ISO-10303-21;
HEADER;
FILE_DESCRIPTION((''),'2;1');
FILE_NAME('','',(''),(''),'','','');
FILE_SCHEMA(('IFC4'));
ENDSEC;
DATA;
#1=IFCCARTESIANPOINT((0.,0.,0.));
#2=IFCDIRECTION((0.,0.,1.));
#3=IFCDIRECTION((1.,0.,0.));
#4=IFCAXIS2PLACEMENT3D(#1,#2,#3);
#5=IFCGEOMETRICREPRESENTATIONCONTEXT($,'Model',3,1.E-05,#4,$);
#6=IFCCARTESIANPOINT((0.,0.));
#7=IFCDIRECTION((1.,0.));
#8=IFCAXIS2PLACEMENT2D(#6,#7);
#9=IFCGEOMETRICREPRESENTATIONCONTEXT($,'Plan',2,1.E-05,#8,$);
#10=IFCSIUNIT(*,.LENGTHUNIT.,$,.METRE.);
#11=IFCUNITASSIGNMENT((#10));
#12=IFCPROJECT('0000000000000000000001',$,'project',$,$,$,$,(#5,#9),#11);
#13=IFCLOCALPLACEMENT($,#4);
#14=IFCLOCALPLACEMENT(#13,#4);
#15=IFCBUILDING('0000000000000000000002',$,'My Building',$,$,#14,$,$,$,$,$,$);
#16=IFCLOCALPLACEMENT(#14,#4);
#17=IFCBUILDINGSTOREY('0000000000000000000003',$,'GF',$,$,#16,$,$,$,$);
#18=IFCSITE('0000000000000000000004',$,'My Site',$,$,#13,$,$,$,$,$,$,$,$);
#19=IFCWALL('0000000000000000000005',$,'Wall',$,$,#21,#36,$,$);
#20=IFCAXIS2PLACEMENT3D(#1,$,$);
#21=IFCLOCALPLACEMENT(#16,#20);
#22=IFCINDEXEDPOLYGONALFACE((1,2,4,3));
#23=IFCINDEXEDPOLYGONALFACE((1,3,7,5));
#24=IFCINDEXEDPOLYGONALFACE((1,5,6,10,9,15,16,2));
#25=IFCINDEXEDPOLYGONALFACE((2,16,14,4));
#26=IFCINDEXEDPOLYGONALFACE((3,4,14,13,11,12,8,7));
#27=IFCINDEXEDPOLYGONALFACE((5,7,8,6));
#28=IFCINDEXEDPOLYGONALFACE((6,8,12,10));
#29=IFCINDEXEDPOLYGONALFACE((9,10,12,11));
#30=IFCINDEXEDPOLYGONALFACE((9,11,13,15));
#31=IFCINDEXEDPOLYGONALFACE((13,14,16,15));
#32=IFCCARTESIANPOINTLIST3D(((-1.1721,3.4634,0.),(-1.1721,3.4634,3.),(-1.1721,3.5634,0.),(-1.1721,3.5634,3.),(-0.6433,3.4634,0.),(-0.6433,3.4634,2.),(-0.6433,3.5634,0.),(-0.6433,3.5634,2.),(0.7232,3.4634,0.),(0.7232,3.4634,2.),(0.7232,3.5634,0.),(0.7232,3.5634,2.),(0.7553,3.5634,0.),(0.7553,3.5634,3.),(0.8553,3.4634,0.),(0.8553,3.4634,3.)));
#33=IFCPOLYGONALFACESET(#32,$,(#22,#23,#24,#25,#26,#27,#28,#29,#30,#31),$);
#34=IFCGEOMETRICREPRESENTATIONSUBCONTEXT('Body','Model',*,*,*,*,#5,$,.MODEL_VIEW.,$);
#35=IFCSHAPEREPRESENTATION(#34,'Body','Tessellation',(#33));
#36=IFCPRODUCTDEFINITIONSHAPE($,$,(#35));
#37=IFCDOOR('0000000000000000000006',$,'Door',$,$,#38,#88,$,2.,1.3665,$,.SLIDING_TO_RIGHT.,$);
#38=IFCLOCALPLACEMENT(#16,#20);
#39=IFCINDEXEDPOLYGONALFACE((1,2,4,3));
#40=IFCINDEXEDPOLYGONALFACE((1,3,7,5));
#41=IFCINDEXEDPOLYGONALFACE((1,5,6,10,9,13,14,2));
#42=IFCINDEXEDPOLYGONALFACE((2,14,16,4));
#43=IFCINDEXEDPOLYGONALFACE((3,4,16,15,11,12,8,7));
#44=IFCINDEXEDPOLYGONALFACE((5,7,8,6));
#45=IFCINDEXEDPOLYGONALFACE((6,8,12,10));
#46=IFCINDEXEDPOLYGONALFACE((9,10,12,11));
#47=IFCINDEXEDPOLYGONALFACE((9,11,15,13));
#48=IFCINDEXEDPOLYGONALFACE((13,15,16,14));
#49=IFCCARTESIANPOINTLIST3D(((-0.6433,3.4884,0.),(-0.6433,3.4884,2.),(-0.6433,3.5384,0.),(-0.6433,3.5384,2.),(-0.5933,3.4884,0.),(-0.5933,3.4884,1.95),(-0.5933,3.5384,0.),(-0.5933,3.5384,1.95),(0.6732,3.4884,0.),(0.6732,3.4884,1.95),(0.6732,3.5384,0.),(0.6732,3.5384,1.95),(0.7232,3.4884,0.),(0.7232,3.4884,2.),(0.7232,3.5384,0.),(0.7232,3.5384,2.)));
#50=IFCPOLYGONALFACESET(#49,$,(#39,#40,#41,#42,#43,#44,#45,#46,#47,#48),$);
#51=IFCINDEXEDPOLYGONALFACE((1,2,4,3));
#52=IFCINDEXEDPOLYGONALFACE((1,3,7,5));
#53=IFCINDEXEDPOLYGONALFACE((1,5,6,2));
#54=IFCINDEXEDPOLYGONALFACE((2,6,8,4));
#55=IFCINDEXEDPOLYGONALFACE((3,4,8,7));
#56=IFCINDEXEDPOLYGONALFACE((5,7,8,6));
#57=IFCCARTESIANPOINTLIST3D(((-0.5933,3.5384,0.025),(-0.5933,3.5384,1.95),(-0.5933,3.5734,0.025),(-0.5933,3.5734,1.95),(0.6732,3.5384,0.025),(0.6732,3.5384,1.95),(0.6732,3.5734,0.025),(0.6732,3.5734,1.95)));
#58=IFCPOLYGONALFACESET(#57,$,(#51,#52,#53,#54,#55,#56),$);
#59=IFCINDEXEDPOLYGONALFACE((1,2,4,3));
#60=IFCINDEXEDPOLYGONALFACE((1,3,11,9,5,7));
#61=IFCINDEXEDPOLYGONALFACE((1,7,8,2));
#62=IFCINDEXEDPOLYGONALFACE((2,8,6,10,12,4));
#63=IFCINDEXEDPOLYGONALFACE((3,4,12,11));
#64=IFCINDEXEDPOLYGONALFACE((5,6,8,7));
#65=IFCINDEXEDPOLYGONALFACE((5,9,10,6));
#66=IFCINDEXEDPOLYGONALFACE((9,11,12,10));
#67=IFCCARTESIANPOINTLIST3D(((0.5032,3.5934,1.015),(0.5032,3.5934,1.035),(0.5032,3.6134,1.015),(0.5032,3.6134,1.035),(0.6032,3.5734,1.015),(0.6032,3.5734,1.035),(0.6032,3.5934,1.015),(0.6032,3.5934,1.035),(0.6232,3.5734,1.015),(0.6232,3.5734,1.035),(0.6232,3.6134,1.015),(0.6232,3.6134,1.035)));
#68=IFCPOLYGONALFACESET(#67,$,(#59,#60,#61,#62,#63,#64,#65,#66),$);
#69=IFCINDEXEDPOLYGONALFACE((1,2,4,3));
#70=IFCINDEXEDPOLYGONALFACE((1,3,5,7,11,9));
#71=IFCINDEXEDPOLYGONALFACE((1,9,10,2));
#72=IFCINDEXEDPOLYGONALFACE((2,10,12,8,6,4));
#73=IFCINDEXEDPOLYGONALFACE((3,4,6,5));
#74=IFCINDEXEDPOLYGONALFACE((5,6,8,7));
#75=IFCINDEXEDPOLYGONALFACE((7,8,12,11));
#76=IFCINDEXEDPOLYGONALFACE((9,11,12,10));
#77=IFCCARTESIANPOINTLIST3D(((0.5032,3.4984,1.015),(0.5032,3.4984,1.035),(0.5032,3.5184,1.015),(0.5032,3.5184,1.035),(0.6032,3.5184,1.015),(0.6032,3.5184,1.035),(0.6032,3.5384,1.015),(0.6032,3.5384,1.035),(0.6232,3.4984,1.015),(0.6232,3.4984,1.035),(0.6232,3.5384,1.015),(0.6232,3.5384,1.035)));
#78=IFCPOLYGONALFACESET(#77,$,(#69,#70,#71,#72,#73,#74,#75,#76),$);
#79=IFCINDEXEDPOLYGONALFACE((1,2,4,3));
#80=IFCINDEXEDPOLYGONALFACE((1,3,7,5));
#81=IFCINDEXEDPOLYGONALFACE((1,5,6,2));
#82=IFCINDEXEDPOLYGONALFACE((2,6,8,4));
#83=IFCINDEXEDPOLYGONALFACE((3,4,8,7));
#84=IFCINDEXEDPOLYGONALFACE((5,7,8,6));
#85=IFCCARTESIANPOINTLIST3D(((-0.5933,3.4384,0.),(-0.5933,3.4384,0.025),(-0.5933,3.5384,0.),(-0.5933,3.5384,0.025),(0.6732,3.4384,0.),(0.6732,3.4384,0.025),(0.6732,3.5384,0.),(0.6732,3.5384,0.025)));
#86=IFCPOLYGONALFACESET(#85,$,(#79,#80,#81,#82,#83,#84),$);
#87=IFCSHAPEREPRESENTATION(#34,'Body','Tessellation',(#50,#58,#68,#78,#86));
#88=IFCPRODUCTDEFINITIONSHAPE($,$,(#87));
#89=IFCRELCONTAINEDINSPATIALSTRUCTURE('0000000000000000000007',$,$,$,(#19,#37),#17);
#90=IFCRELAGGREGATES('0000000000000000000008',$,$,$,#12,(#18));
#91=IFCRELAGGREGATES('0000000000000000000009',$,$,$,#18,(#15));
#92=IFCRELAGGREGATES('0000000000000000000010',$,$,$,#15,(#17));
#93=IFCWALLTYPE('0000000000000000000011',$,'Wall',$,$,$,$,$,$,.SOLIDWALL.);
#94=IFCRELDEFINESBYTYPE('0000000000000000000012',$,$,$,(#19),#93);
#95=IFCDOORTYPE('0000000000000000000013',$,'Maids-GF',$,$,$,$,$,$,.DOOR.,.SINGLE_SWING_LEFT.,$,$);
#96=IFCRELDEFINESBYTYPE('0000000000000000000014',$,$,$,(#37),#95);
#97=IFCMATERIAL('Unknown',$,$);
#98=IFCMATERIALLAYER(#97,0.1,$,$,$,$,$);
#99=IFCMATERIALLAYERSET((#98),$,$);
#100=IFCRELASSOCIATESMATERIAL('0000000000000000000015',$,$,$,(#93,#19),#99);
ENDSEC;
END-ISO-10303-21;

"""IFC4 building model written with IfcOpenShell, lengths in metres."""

from ifc_helpers import new_model, entity, si_unit, frame, origin_with_axes, origin_2d_with_axis, place, context, subcontext, project, spatial, line, indexed_curve, outline, extrude, shape, source, transform, mapped, material, layer, layer_set, layer_usage, type_object, type_shapes, element, fill, save


model = new_model("IFC4")

# Units and contexts
model_context = context("Model", 3, precision=1e-05, world=origin_with_axes())
plan_context = context("Plan", 2, precision=1e-05, world=origin_2d_with_axis())
body_context_1 = subcontext(model_context, "Body", "Model", "MODEL_VIEW")
body_context_2 = subcontext(plan_context, "Body", "Plan", "PLAN_VIEW")
ifc_project = project(units=[si_unit("LENGTHUNIT", "METRE")], contexts=[model_context, plan_context])

# Site, building, storey
site_placement = place(None, origin_with_axes())
site = spatial("IfcSite", under=ifc_project, at=site_placement, Name="My Site")
building_placement = place(site_placement, origin_with_axes())
building = spatial("IfcBuilding", under=site, at=building_placement, Name="My Building")
storey_placement = place(building_placement, origin_with_axes())
storey = spatial("IfcBuildingStorey", under=building, at=storey_placement, Name="GF")

# Shared definitions
ifc_material_1 = material(Name="Unknown")

# Shared definitions
ifc_layer_1 = layer(ifc_material_1, 0.1)
ifc_layer_set_1 = layer_set([ifc_layer_1])
wall_type = type_object("IfcWallType", Name="Wall", PredefinedType="SOLIDWALL", material=ifc_layer_set_1)

# Wall, opening, door
ifc_layer_usage_1 = layer_usage(ifc_layer_set_1, "AXIS2", "POSITIVE", 0.0)
wall_1_placement = place(storey_placement, frame((0.7553, 3.5634, 0.0), z_axis=(0.0, 0.0, 1.0), x_axis=(-1.0, 0.0, 0.0)))
wall_1 = element("IfcWall", 1, at=wall_1_placement, inside=storey, type_object=wall_type, material=ifc_layer_usage_1, Name="Wall", context=body_context_1, shape_type="SweptSolid", body=[
    extrude(outline(indexed_curve([(0.0, 0.0), (-0.1, 0.1), (1.9273, 0.1), (1.9273, 0.0)], segments=[line(1, 2, 3, 4, 1)])), origin_with_axes(), (0.0, 0.0, 1.0), 3.0),
])
shared_shape_1 = source(origin_with_axes(), body_context_1, "Body", "SweptSolid", [
    extrude(outline(indexed_curve([(0.0, 0.0), (1.3665, 0.0), (1.3665, 2.0), (0.0, 2.0)], segments=[line(1, 2, 3, 4, 1)])), frame((0.0, -0.6, 0.0), z_axis=(0.0, -1.0, 0.0), x_axis=(1.0, 0.0, 0.0)), (0.0, 0.0, -1.0), 1.2),
])
opening_1_placement = place(wall_1_placement, frame((0.0321, 0.025, 0.0), z_axis=(0.0, 0.0, 1.0), x_axis=(1.0, 0.0, 0.0)))
opening_1 = element("IfcOpeningElement", 2, at=opening_1_placement, cuts=wall_1, PredefinedType="OPENING", context=body_context_1, shape_type="MappedRepresentation", body=[
    mapped(shared_shape_1, transform((0.0, 0.0, 0.0), x_axis=(1.0, 0.0, 0.0), y_axis=(0.0, 1.0, 0.0), z_axis=(0.0, 0.0, 1.0), scale=1.0)),
])
door_type_1 = type_object("IfcDoorType", Name="Maids-GF", OperationType="SINGLE_SWING_LEFT", PredefinedType="DOOR")
shared_shape_2 = source(origin_with_axes(), body_context_1, "Body", "SweptSolid", [
    extrude(outline(indexed_curve([(0.0, 0.0), (0.0, 2.0), (1.3665, 2.0), (1.3665, 0.0), (1.3165, 0.0), (1.3165, 1.95), (0.05, 1.95), (0.05, 0.0)], segments=[line(1, 2, 3, 4, 5, 6, 7, 8, 1)])), frame((0.0, 0.0, 0.0), z_axis=(0.0, -1.0, 0.0), x_axis=(1.0, 0.0, 0.0)), (0.0, 0.0, -1.0), 0.05),
    extrude(outline(indexed_curve([(0.0, 0.0), (1.2665, 0.0), (1.2665, 0.035), (0.0, 0.035)], segments=[line(1, 2, 3, 4, 1)])), frame((0.05, -0.035, 0.025), z_axis=(0.0, 0.0, 1.0), x_axis=(1.0, 0.0, 0.0)), (0.0, 0.0, 1.0), 1.925),
    extrude(outline(indexed_curve([(0.0, 0.0), (0.0, -0.04), (0.12, -0.04), (0.12, -0.02), (0.02, -0.02), (0.02, 0.0)], segments=[line(1, 2, 3, 4, 5, 6, 1)])), frame((0.1, -0.035, 1.015), z_axis=(0.0, 0.0, 1.0), x_axis=(1.0, 0.0, 0.0)), (0.0, 0.0, 1.0), 0.02),
    extrude(outline(indexed_curve([(0.0, 0.0), (0.0, 0.04), (0.12, 0.04), (0.12, 0.02), (0.02, 0.02), (0.02, 0.0)], segments=[line(1, 2, 3, 4, 5, 6, 1)])), frame((0.1, 0.0, 1.015), z_axis=(0.0, 0.0, 1.0), x_axis=(1.0, 0.0, 0.0)), (0.0, 0.0, 1.0), 0.02),
    extrude(outline(indexed_curve([(0.0, 0.0), (1.2665, 0.0), (1.2665, 0.1), (0.0, 0.1)], segments=[line(1, 2, 3, 4, 1)])), frame((0.05, 0.0, 0.0), z_axis=(0.0, 0.0, 1.0), x_axis=(1.0, 0.0, 0.0)), (0.0, 0.0, 1.0), 0.025),
])
shared_shape_3 = source(origin_with_axes(), body_context_2, "Body", "Curve2D", [
    entity("IfcIndexedPolyCurve", entity("IfcCartesianPointList2D", [[0.0, 0.0], [0.05, 0.0], [0.05, 0.05], [0.0, 0.05]]), [entity("IfcLineIndex", [1, 2, 3, 4, 1])]),
    entity("IfcIndexedPolyCurve", entity("IfcCartesianPointList2D", [[1.3665, 0.0], [1.3165, 0.0], [1.3165, 0.05], [1.3665, 0.05]]), [entity("IfcLineIndex", [1, 2, 3, 4, 1])]),
    entity("IfcIndexedPolyCurve", entity("IfcCartesianPointList2D", [[1.9498, -0.035], [0.6833, -0.035], [0.6833, 0.0], [1.9498, 0.0]]), [entity("IfcLineIndex", [1, 2, 3, 4, 1])]),
])
type_shapes(door_type_1, [shared_shape_2, shared_shape_3])
door_1_placement = place(opening_1_placement, frame((0.0, 0.0, 0.0), z_axis=(0.0, 0.0, 1.0), x_axis=(1.0, 0.0, 0.0)))
door_1 = element("IfcDoor", 3, at=door_1_placement, inside=storey, type_object=door_type_1, Name="Door", OperationType="SLIDING_TO_RIGHT", OverallHeight=2.0, OverallWidth=1.3665, shapes=[
    shape(body_context_1, "Body", "MappedRepresentation", [mapped(shared_shape_2, transform((0.0, 0.0, 0.0), x_axis=(1.0, 0.0, 0.0), y_axis=(0.0, 1.0, 0.0), z_axis=(0.0, 0.0, 1.0), scale=1.0))]),
    shape(body_context_2, "Body", "MappedRepresentation", [mapped(shared_shape_3, transform((0.0, 0.0, 0.0), x_axis=(1.0, 0.0, 0.0), y_axis=(0.0, 1.0, 0.0), z_axis=(0.0, 0.0, 1.0), scale=1.0))]),
])
fill(opening_1, door_1)

save(model, "model.ifc")
